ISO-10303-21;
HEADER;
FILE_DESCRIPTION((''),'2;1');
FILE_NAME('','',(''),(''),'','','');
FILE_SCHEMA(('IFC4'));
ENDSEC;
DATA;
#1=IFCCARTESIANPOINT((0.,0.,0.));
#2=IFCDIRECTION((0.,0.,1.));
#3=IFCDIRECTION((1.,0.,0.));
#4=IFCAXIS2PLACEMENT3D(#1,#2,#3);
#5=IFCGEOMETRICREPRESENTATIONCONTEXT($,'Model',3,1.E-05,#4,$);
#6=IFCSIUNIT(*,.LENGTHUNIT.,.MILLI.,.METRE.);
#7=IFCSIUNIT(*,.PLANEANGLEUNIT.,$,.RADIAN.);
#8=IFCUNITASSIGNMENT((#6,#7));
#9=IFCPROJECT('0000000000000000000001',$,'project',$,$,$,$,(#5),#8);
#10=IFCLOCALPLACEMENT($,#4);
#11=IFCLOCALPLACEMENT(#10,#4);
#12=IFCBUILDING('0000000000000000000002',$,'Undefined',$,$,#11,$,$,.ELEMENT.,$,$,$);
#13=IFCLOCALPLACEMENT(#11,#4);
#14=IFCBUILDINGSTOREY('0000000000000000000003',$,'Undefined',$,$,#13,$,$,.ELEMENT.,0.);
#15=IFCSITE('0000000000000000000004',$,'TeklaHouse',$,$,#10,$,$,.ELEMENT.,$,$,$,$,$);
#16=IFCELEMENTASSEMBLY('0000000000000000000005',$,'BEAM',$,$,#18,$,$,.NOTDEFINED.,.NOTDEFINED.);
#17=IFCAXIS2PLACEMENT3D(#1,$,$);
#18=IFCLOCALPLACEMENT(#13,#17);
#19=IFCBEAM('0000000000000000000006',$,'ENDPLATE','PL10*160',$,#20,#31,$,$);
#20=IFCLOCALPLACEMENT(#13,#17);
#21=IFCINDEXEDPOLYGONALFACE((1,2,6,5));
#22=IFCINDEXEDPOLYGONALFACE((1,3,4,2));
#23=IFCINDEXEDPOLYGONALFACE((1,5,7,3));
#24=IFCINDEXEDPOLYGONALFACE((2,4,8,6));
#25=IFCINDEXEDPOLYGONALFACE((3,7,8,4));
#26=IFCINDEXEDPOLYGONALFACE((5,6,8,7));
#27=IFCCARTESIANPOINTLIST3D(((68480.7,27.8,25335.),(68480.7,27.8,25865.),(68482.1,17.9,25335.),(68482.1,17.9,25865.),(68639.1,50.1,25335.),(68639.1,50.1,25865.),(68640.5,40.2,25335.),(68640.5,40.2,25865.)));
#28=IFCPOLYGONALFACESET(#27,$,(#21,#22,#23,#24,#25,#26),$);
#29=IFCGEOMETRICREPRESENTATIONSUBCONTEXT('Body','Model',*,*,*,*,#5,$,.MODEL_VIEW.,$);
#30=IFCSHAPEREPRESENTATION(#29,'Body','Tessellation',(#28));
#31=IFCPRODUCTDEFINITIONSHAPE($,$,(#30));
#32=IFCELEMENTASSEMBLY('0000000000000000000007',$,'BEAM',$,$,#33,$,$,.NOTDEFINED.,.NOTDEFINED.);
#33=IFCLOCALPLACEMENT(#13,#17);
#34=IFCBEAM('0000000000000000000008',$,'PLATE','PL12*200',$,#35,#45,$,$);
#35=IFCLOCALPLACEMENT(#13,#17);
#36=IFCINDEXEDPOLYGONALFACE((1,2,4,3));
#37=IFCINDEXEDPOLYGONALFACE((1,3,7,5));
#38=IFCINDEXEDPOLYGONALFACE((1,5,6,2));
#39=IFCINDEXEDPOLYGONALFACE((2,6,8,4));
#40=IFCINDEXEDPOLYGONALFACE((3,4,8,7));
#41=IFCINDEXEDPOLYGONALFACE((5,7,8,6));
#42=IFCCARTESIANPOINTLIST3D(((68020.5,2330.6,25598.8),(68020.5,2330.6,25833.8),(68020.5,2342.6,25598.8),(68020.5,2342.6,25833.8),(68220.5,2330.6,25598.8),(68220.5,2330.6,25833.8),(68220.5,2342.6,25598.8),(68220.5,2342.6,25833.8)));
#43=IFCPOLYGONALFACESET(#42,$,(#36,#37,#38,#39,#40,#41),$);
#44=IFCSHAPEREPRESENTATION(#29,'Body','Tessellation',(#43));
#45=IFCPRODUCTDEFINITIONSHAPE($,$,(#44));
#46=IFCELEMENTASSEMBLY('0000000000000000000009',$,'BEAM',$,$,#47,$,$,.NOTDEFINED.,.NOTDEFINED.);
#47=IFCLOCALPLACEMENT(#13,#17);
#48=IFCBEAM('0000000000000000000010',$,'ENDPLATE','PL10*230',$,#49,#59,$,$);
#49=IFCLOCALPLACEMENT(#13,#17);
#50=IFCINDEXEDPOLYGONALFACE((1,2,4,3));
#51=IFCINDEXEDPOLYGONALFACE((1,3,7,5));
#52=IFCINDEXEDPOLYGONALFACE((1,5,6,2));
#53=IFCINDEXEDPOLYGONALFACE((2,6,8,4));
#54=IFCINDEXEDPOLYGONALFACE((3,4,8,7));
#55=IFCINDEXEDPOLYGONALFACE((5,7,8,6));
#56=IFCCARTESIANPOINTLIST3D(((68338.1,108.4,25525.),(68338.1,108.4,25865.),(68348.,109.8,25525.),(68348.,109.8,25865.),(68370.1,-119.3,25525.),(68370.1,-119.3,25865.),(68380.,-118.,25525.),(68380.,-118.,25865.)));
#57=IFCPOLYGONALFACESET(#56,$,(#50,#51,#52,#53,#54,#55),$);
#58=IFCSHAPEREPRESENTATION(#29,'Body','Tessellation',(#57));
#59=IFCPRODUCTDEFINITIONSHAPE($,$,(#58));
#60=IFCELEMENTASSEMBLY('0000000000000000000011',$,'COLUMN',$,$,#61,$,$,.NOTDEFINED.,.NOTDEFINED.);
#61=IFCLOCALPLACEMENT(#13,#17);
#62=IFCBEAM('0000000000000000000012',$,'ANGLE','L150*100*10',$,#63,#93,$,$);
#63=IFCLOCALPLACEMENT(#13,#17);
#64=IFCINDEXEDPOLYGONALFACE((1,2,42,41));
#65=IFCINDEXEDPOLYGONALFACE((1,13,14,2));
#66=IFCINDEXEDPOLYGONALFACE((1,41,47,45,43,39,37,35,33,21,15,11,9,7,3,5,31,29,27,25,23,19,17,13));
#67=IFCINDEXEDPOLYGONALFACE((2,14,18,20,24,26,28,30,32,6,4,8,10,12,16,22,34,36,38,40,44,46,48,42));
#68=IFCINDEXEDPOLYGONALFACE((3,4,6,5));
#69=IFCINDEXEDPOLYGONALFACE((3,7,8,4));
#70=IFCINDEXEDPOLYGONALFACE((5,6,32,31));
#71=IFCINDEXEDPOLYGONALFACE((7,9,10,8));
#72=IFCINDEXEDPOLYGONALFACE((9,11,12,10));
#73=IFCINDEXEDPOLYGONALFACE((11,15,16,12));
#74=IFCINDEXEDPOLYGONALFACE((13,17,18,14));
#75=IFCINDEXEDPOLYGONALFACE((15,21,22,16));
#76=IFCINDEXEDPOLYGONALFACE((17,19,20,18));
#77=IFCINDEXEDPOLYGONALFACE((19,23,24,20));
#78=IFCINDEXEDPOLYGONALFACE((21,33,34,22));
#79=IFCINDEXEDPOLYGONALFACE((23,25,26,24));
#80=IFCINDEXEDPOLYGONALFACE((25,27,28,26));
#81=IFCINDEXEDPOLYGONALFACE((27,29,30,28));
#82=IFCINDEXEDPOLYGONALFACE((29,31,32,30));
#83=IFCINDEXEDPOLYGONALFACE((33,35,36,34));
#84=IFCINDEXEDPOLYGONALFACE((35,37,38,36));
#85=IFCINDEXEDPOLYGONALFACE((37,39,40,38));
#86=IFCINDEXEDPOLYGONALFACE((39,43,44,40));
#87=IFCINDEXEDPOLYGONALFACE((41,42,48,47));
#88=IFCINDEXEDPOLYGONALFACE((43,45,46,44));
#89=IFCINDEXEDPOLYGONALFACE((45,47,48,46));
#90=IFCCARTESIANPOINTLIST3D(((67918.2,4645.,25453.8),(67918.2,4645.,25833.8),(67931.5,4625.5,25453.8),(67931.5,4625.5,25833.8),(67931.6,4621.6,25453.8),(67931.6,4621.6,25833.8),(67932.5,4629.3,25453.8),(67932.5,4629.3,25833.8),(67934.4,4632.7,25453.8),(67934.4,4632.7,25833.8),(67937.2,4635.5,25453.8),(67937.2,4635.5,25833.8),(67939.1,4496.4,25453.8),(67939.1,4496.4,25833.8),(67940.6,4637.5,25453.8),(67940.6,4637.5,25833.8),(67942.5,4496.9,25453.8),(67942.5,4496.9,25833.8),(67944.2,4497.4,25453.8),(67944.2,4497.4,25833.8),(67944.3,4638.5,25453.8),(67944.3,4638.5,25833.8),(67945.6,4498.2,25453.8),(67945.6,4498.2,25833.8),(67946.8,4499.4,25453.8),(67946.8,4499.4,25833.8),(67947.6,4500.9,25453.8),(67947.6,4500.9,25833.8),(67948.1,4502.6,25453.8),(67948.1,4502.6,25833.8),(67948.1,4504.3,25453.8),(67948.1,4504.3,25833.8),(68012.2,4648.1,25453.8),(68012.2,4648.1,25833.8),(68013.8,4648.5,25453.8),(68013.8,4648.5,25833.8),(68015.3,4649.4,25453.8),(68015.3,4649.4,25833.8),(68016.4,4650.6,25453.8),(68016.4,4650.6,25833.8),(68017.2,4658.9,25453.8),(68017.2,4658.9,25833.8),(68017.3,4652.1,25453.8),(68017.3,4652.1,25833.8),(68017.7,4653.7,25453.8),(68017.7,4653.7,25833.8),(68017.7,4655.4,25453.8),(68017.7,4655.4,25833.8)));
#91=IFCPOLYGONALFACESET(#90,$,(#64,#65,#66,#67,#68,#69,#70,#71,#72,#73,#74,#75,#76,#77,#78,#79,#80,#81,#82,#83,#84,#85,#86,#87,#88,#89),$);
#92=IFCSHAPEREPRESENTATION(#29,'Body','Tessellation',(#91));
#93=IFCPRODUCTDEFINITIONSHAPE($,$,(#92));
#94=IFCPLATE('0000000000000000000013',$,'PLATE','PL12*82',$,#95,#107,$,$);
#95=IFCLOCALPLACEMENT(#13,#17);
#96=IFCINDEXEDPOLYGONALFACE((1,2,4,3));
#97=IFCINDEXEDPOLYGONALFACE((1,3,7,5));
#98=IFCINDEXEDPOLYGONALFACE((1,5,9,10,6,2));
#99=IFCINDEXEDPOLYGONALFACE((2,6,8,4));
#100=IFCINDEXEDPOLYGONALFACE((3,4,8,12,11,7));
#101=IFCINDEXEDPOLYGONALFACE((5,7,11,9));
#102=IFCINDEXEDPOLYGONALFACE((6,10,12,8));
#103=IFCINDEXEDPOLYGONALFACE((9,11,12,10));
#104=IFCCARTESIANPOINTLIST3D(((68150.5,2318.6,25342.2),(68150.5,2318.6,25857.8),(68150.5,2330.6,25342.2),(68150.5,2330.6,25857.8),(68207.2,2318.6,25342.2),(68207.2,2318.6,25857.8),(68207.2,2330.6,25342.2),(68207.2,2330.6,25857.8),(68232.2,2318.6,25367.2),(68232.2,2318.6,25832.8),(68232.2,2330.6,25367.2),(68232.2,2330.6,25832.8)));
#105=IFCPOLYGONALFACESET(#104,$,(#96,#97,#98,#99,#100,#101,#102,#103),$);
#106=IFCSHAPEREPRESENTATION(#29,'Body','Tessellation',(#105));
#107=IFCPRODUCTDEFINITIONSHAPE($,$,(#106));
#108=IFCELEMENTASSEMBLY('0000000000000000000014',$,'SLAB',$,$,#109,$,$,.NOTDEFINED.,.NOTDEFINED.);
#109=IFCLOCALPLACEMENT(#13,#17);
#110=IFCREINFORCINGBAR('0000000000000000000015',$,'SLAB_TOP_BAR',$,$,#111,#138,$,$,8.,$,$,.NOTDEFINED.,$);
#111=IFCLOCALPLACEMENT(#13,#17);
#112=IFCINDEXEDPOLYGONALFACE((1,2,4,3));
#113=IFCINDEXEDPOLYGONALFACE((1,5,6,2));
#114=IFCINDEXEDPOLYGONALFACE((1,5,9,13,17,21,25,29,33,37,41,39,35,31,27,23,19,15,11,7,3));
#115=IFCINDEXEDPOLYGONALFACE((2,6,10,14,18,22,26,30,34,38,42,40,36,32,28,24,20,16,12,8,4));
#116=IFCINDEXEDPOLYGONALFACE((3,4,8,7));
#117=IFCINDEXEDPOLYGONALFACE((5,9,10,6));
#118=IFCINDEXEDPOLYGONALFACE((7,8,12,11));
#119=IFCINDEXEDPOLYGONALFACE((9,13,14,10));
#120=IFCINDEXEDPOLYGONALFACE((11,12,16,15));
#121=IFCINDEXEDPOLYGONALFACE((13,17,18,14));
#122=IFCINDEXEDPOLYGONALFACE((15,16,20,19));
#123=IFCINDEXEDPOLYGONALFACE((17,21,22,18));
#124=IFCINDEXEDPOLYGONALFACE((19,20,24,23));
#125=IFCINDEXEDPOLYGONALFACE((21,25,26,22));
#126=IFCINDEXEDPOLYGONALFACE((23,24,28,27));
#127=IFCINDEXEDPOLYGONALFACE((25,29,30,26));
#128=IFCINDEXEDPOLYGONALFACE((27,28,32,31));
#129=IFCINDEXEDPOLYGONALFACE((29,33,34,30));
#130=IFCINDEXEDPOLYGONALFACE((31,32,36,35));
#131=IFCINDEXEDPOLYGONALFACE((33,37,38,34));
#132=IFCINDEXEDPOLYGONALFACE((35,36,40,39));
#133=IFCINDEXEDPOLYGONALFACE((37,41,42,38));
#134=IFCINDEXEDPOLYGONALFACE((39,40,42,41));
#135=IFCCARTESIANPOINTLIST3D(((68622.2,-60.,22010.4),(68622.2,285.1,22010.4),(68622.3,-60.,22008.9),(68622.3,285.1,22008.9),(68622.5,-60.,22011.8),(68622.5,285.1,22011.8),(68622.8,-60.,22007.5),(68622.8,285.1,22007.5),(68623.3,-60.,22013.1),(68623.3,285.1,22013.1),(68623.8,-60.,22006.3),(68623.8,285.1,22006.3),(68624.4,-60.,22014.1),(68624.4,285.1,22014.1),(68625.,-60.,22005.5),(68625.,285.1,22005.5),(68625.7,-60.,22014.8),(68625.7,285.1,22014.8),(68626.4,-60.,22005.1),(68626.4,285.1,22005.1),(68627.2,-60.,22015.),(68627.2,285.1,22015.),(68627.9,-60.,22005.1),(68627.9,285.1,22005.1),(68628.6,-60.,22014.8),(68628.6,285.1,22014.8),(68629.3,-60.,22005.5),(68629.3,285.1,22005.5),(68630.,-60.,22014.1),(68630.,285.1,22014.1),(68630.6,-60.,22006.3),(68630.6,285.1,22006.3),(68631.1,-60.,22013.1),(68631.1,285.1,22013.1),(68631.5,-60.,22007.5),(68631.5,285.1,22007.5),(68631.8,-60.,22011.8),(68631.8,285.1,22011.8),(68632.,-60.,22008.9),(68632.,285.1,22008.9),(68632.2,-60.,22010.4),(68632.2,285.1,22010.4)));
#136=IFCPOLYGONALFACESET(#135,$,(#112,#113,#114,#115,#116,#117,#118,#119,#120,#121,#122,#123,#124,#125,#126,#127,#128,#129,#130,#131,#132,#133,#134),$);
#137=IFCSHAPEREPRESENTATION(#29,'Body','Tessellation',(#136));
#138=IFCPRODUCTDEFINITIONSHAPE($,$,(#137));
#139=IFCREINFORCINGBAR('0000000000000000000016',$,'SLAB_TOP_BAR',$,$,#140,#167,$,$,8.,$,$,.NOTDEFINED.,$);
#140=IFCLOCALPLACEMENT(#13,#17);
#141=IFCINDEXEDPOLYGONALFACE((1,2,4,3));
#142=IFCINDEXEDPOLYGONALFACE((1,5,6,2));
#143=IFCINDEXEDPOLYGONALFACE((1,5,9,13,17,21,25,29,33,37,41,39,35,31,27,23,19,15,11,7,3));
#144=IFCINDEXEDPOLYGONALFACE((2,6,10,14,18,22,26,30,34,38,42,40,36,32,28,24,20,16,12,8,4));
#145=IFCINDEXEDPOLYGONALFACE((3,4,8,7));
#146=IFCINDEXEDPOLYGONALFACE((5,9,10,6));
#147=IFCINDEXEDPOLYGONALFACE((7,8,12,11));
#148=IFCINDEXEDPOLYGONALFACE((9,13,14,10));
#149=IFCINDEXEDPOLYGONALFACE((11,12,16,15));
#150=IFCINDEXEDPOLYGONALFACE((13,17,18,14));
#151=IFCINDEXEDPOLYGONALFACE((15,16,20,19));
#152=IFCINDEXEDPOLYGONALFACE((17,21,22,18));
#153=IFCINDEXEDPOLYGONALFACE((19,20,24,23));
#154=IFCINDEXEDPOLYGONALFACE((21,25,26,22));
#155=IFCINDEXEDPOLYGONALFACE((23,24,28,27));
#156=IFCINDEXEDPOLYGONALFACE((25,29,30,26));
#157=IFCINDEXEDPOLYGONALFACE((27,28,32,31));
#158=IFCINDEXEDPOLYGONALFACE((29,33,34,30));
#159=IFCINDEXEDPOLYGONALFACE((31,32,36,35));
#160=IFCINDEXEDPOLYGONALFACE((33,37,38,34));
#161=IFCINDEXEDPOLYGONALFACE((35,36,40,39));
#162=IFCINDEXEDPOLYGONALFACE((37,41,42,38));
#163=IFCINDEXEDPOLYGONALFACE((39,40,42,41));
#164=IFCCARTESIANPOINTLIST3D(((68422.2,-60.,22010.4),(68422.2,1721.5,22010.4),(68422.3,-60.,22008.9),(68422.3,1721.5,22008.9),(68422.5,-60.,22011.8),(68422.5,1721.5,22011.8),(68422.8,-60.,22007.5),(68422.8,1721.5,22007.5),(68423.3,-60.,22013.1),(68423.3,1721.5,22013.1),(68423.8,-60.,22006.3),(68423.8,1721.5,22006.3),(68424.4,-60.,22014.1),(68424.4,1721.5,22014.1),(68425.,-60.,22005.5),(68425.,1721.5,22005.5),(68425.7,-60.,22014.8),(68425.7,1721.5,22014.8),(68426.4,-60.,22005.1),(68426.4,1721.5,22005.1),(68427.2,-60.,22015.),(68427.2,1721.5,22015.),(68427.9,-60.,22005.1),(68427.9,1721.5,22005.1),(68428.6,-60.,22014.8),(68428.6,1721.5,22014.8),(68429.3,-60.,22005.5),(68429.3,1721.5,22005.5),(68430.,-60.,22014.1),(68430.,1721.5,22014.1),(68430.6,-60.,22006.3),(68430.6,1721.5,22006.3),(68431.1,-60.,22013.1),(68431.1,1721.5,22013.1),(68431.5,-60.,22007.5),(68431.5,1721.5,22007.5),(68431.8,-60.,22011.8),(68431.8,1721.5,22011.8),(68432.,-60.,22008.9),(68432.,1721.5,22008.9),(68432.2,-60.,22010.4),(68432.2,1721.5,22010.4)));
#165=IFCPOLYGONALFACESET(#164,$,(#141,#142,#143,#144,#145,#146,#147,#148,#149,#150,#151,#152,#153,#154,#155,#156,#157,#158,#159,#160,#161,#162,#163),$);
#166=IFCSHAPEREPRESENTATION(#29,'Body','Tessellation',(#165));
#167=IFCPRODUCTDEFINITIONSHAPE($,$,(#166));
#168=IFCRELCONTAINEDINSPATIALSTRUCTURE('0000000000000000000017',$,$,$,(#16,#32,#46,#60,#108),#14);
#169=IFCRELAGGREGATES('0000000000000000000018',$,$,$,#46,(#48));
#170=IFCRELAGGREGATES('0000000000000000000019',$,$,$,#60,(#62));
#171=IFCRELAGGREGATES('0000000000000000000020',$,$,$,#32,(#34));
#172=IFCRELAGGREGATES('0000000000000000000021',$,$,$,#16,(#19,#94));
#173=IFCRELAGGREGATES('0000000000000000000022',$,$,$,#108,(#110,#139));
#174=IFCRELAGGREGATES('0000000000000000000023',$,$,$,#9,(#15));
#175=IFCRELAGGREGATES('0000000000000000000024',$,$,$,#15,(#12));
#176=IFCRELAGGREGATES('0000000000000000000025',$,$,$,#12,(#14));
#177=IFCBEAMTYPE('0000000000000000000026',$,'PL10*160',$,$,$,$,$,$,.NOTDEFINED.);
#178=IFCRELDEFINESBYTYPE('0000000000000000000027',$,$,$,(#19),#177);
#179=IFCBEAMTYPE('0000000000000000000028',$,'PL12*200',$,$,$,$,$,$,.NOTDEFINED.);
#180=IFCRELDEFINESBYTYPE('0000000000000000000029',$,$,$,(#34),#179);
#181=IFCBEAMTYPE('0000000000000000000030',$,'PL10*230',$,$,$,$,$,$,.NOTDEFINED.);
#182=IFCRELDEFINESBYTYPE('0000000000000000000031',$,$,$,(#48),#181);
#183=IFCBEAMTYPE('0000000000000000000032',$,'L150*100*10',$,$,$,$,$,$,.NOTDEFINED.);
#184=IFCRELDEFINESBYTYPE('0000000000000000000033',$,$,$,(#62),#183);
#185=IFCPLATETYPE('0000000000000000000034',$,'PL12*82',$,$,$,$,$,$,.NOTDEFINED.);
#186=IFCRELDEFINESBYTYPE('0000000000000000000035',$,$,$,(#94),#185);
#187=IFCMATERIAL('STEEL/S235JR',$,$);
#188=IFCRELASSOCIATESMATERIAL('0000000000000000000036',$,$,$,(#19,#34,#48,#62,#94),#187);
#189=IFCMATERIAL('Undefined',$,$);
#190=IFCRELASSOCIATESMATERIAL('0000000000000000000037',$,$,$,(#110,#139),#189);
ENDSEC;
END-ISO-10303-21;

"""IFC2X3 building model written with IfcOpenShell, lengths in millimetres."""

from ifc_helpers import new_model, entity, si_unit, frame, origin_with_axes, origin_2d_with_axis, place, context, subcontext, project, spatial, polyline, rectangle, l_section, outline, extrude, source, transform, mapped, material, type_object, element, aggregate, save


model = new_model("IFC2X3")

# Units and contexts
model_context = context("Model", 3, precision=1e-05, world=origin_with_axes())
body_context = subcontext(model_context, "Body", "Model", "MODEL_VIEW")
ifc_project = project(units=[si_unit("LENGTHUNIT", "METRE", prefix="MILLI"), si_unit("PLANEANGLEUNIT", "RADIAN")], contexts=[model_context])

# Site, building, storey
site_placement = place(None, origin_with_axes())
site = spatial("IfcSite", under=ifc_project, at=site_placement, Name="TeklaHouse", CompositionType="ELEMENT")
building_placement = place(site_placement, origin_with_axes())
building = spatial("IfcBuilding", under=site, at=building_placement, Name="Undefined", CompositionType="ELEMENT")
storey_placement = place(building_placement, origin_with_axes())
storey = spatial("IfcBuildingStorey", under=building, at=storey_placement, Name="Undefined", CompositionType="ELEMENT", Elevation=0.0)

# Element assemblies, beams
assembly_1_placement = place(storey_placement, origin_with_axes())
assembly_1 = element("IfcElementAssembly", 1, at=assembly_1_placement, inside=storey, Name="BEAM", AssemblyPlace="NOTDEFINED", PredefinedType="NOTDEFINED")
ifc_material_1 = material(Name="STEEL/S235JR")
beam_type_1 = type_object("IfcBeamType", Name="PL10*160", PredefinedType="NOTDEFINED")
beam_1_placement = place(assembly_1_placement, frame((68560.6, 34.0, 25335.0), z_axis=(0.990268, 0.139172, 0.0), x_axis=(0.0, 0.0, 1.0)))
beam_1 = element("IfcBeam", 2, at=beam_1_placement, type_object=beam_type_1, material=ifc_material_1, Name="ENDPLATE", Description="PL10*160", context=body_context, shape_type="SweptSolid", body=[
    extrude(rectangle(XDim=10.0, YDim=160.0, at=origin_2d_with_axis()), frame((530.0, 0.0, 0.0), z_axis=(-1.0, 0.0, 0.0), x_axis=(0.0, -1.0, 0.0)), (0.0, 0.0, 1.0), 530.0),
])
assembly_2_placement = place(storey_placement, origin_with_axes())
assembly_2 = element("IfcElementAssembly", 3, at=assembly_2_placement, inside=storey, Name="BEAM", AssemblyPlace="NOTDEFINED", PredefinedType="NOTDEFINED")
beam_type_2 = type_object("IfcBeamType", Name="PL12*200", PredefinedType="NOTDEFINED")
beam_2_placement = place(assembly_2_placement, frame((68120.5, 2336.6, 25598.8), z_axis=(1.0, 0.0, 0.0), x_axis=(0.0, 0.0, 1.0)))
beam_2 = element("IfcBeam", 4, at=beam_2_placement, type_object=beam_type_2, material=ifc_material_1, Name="PLATE", Description="PL12*200", context=body_context, shape_type="SweptSolid", body=[
    extrude(rectangle(XDim=12.0, YDim=200.0, at=origin_2d_with_axis()), frame((235.0, 0.0, 0.0), z_axis=(-1.0, 0.0, 0.0), x_axis=(0.0, -1.0, 0.0)), (0.0, 0.0, 1.0), 235.0),
])
assembly_3_placement = place(storey_placement, origin_with_axes())
assembly_3 = element("IfcElementAssembly", 5, at=assembly_3_placement, inside=storey, Name="BEAM", AssemblyPlace="NOTDEFINED", PredefinedType="NOTDEFINED")
beam_type_3 = type_object("IfcBeamType", Name="PL10*230", PredefinedType="NOTDEFINED")
beam_3_placement = place(assembly_3_placement, frame((68359.0, -4.8, 25525.0), z_axis=(-0.139172, 0.990268, 0.0), x_axis=(0.0, 0.0, 1.0)))
beam_3 = element("IfcBeam", 6, at=beam_3_placement, type_object=beam_type_3, material=ifc_material_1, Name="ENDPLATE", Description="PL10*230", context=body_context, shape_type="SweptSolid", body=[
    extrude(rectangle(XDim=10.0, YDim=230.0, at=origin_2d_with_axis()), frame((340.0, 0.0, 0.0), z_axis=(-1.0, 0.0, 0.0), x_axis=(0.0, -1.0, 0.0)), (0.0, 0.0, 1.0), 340.0),
])
aggregate(assembly_3, [beam_3])
assembly_4_placement = place(storey_placement, origin_with_axes())
assembly_4 = element("IfcElementAssembly", 7, at=assembly_4_placement, inside=storey, Name="COLUMN", AssemblyPlace="NOTDEFINED", PredefinedType="NOTDEFINED")
beam_type_4 = type_object("IfcBeamType", Name="L150*100*10", PredefinedType="NOTDEFINED")
beam_4_placement = place(assembly_4_placement, frame((67978.1, 4577.7, 25453.8), z_axis=(0.139172, -0.990268, 0.0), x_axis=(0.0, 0.0, 1.0)))
beam_4 = element("IfcBeam", 8, at=beam_4_placement, type_object=beam_type_4, material=ifc_material_1, Name="ANGLE", Description="L150*100*10", context=body_context, shape_type="SweptSolid", body=[
    extrude(l_section(Depth=150.0, Width=100.0, Thickness=10.0, FilletRadius=15.0, EdgeRadius=6.5, at=origin_2d_with_axis()), frame((380.0, 0.0, 0.0), z_axis=(-1.0, 0.0, 0.0), x_axis=(0.0, -1.0, 0.0)), (0.0, 0.0, 1.0), 380.0),
])
aggregate(assembly_4, [beam_4])

# Plate
plate_type = type_object("IfcPlateType", Name="PL12*82", PredefinedType="NOTDEFINED")
plate_placement = place(assembly_1_placement, frame((68232.2, 2324.6, 25342.2), z_axis=(0.0, 1.0, 0.0), x_axis=(-1.0, 0.0, 0.0)))
plate = element("IfcPlate", 9, at=plate_placement, type_object=plate_type, material=ifc_material_1, Name="PLATE", Description="PL12*82", context=body_context, shape_type="SweptSolid", body=[
    extrude(outline(polyline([(0.0, 25.0), (25.0, 0.0), (81.7, 0.0), (81.7, 515.6), (25.0, 515.6), (0.0, 490.6), (0.0, 25.0)])), frame((0.0, 0.0, -6.0), z_axis=(0.0, 0.0, 1.0), x_axis=(1.0, 0.0, 0.0)), (0.0, 0.0, 1.0), 12.0),
])

# Shared definitions
ifc_material_2 = material(Name="Undefined")
aggregate(assembly_2, [beam_2])
aggregate(assembly_1, [beam_1, plate])

# Element assembly, reinforcing bars
assembly_5_placement = place(storey_placement, origin_with_axes())
assembly_5 = element("IfcElementAssembly", 10, at=assembly_5_placement, inside=storey, Name="SLAB", AssemblyPlace="NOTDEFINED", PredefinedType="NOTDEFINED")
shared_shape_1 = source(origin_with_axes(), body_context, "Body", "AdvancedSweptSolid", [
    entity("IfcSweptDiskSolid", entity("IfcTrimmedCurve", entity("IfcLine", entity("IfcCartesianPoint", [0.0, 0.0, 0.0]), entity("IfcVector", entity("IfcDirection", [1.0, 0.0, 0.0]), 1.0)), [entity("IfcParameterValue", 0.0)], [entity("IfcParameterValue", 345.095146)], True, "PARAMETER"), 5.0, None, 0.0, 345.1),
])
reinforcing_bar_1_placement = place(assembly_5_placement, frame((68627.2, -60.0, 22010.0), z_axis=(0.0, 0.0, 1.0), x_axis=(0.0, 1.0, 0.0)))
reinforcing_bar_1 = element("IfcReinforcingBar", 11, at=reinforcing_bar_1_placement, material=ifc_material_2, Name="SLAB_TOP_BAR", BarRole="NOTDEFINED", NominalDiameter=8.0, context=body_context, shape_type="MappedRepresentation", body=[
    mapped(shared_shape_1, transform((0.0, 0.0, 0.0))),
])
shared_shape_2 = source(origin_with_axes(), body_context, "Body", "AdvancedSweptSolid", [
    entity("IfcSweptDiskSolid", entity("IfcTrimmedCurve", entity("IfcLine", entity("IfcCartesianPoint", [0.0, 0.0, 0.0]), entity("IfcVector", entity("IfcDirection", [1.0, 0.0, 0.0]), 1.0)), [entity("IfcParameterValue", 0.0)], [entity("IfcParameterValue", 1781.543595)], True, "PARAMETER"), 5.0, None, 0.0, 1781.5),
])
reinforcing_bar_2_placement = place(assembly_5_placement, frame((68427.2, -60.0, 22010.0), z_axis=(0.0, 0.0, 1.0), x_axis=(0.0, 1.0, 0.0)))
reinforcing_bar_2 = element("IfcReinforcingBar", 12, at=reinforcing_bar_2_placement, material=ifc_material_2, Name="SLAB_TOP_BAR", BarRole="NOTDEFINED", NominalDiameter=8.0, context=body_context, shape_type="MappedRepresentation", body=[
    mapped(shared_shape_2, transform((0.0, 0.0, 0.0))),
])
aggregate(assembly_5, [reinforcing_bar_1, reinforcing_bar_2])

save(model, "model.ifc")
